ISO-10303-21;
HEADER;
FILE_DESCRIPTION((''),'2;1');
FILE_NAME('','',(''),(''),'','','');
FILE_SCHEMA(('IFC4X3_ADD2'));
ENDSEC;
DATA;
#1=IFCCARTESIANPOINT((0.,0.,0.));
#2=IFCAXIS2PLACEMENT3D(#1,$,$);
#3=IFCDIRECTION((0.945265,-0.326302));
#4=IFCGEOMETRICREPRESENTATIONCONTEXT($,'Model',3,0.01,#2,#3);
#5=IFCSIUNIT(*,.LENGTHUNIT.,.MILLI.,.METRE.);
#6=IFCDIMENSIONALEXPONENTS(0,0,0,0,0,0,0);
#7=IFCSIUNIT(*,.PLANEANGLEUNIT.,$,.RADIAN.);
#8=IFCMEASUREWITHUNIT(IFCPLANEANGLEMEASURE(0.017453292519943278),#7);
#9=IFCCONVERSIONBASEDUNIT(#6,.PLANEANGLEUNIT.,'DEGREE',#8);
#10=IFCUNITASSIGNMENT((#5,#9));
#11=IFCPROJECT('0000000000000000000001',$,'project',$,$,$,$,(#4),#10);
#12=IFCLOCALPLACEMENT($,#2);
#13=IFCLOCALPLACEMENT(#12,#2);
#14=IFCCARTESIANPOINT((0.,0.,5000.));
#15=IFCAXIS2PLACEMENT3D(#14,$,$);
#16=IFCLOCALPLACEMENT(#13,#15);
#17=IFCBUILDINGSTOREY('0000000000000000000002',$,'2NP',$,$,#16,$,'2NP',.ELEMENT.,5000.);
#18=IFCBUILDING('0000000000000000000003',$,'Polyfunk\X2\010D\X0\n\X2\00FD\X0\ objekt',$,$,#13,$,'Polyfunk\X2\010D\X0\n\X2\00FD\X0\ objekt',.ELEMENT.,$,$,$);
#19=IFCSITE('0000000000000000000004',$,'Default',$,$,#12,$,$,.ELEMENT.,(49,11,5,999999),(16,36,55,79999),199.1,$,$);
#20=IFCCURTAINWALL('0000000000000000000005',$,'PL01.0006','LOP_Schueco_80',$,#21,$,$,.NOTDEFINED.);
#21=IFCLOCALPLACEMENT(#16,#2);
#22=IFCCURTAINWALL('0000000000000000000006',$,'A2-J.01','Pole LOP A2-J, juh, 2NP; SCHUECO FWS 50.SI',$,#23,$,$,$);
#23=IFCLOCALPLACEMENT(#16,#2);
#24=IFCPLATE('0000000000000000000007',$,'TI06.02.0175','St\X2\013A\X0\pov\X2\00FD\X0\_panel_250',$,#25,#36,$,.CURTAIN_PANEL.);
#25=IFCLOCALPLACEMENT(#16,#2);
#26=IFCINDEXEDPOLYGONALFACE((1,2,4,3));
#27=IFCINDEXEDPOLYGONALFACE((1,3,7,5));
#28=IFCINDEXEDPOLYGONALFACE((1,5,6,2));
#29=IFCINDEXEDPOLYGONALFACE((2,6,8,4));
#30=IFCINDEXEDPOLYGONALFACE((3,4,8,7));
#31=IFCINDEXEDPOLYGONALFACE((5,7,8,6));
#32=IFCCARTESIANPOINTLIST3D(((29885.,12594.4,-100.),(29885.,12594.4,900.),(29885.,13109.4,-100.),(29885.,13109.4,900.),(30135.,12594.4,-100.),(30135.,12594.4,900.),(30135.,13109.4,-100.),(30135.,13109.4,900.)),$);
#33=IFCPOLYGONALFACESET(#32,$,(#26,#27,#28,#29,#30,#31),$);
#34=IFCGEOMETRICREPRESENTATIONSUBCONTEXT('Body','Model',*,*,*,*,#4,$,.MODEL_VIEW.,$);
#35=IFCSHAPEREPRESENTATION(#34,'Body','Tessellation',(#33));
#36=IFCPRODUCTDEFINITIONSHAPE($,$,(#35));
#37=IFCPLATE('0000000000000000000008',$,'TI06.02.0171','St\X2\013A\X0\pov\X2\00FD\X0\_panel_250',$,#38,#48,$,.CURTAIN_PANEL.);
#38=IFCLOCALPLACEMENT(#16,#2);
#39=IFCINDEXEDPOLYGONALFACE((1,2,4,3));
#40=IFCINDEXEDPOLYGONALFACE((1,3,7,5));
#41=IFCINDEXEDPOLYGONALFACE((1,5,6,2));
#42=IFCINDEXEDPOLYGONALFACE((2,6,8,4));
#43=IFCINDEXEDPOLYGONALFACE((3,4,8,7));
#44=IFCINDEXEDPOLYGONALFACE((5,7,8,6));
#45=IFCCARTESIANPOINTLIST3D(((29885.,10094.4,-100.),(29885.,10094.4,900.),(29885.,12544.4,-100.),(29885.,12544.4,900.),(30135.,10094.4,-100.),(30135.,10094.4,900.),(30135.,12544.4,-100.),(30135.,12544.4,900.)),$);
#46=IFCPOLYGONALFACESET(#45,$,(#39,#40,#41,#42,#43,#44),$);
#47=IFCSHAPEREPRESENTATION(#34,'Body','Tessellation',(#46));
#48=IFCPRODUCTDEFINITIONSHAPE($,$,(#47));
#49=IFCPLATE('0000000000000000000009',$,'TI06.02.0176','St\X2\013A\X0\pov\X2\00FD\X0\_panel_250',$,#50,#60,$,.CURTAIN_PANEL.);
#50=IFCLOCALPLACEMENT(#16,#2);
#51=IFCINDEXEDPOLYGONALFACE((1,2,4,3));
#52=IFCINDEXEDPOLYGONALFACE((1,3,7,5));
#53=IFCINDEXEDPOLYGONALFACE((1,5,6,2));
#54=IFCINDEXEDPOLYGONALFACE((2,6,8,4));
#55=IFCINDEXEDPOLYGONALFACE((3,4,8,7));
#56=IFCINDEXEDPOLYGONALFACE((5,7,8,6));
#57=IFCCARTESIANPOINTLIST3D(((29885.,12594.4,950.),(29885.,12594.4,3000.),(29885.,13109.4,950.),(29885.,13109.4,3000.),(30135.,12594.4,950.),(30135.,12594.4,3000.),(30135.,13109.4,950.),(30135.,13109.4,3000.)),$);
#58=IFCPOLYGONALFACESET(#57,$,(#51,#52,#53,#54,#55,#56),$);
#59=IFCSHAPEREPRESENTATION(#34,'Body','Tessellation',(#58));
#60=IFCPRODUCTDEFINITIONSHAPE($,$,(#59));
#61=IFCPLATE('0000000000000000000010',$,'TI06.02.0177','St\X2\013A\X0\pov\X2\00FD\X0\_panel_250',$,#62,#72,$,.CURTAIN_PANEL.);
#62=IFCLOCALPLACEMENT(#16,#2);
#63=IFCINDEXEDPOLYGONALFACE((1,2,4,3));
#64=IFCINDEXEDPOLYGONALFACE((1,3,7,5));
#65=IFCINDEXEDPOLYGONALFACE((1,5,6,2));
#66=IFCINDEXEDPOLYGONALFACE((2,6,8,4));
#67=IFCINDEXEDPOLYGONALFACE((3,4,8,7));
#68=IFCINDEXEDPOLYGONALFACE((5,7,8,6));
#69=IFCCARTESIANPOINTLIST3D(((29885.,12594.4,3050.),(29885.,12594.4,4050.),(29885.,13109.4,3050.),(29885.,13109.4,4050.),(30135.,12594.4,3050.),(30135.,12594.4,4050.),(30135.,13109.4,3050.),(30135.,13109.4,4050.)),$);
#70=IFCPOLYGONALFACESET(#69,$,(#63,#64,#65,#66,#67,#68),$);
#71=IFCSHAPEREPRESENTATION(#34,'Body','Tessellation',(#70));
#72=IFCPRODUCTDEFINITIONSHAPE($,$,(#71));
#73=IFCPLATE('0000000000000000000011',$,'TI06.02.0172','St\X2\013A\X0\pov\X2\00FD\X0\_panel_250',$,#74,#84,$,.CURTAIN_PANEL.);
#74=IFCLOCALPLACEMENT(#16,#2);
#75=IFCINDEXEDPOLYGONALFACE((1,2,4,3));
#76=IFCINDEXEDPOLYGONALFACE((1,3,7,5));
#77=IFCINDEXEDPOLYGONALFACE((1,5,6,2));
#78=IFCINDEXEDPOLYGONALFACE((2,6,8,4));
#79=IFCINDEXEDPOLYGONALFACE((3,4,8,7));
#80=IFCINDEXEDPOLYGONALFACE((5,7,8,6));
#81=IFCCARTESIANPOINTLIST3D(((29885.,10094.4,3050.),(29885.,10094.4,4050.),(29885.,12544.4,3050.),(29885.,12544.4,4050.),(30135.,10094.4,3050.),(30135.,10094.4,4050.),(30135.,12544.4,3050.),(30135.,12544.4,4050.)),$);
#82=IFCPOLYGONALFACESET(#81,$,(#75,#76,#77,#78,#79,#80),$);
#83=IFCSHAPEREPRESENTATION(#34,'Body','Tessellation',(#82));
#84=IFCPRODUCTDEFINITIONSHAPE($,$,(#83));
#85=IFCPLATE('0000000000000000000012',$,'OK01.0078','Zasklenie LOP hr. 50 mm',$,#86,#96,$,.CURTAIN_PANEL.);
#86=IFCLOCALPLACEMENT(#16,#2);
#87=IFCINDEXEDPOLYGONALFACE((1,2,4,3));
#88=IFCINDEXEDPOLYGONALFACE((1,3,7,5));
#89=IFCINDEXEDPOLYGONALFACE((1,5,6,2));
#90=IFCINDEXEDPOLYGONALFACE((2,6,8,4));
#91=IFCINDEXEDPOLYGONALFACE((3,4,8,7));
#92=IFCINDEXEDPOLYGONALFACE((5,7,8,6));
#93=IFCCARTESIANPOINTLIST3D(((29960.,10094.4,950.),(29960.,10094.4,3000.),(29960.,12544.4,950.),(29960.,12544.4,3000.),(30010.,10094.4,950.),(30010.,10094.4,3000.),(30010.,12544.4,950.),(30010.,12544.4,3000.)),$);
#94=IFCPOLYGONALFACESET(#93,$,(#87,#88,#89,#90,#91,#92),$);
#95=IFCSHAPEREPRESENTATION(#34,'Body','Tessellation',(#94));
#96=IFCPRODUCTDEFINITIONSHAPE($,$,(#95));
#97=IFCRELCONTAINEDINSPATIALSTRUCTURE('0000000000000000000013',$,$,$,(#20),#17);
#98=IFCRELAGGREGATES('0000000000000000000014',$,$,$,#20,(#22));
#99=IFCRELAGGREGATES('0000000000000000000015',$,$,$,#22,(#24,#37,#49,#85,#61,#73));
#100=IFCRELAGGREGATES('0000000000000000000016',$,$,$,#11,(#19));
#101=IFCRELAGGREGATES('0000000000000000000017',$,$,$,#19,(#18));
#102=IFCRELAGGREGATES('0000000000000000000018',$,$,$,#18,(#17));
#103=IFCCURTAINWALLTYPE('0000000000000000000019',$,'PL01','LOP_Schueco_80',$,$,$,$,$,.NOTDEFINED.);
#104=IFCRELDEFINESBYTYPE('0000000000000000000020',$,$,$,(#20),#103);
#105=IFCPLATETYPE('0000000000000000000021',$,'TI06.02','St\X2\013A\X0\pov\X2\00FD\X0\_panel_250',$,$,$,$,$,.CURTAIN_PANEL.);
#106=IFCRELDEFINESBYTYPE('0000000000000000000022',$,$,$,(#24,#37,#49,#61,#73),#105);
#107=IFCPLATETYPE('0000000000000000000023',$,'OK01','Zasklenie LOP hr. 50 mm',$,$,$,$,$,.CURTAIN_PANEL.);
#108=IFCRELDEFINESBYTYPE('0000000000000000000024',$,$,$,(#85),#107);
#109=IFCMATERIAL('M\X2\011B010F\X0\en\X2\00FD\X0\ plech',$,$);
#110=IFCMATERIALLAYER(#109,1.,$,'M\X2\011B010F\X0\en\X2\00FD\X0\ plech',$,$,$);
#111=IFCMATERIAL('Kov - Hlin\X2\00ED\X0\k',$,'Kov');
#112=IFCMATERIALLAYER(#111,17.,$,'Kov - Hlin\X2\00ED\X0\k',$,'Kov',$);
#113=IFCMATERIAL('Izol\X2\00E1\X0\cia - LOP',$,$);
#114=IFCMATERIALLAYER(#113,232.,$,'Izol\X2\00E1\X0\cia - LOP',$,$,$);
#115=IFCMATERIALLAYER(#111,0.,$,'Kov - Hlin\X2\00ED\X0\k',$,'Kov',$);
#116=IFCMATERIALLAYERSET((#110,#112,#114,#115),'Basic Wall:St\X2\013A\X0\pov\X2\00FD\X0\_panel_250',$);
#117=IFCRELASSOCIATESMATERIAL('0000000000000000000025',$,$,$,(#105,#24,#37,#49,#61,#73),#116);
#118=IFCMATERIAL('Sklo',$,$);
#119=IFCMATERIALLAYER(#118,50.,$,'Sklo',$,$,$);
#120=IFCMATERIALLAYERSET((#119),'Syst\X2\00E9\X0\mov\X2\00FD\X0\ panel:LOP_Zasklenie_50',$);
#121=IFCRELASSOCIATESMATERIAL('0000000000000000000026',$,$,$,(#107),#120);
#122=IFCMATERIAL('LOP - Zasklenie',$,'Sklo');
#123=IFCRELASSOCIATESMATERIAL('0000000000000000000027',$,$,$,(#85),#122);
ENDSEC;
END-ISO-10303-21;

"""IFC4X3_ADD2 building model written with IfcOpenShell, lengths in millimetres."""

from ifc_helpers import new_model, entity, si_unit, converted_unit, direction, frame, frame_2d, origin, origin_2d_with_axis, place, context, subcontext, project, spatial, rectangle, extrude, source, transform, mapped, material, layer, layer_set, layer_usage, type_object, type_shapes, element, aggregate, save


model = new_model("IFC4X3_ADD2")

# Units and contexts
model_context = context("Model", 3, precision=0.01, world=origin(), true_north=direction((0.945265, -0.326302)))
body_context = subcontext(model_context, "Body", "Model", "MODEL_VIEW")
ifc_project = project(units=[si_unit("LENGTHUNIT", "METRE", prefix="MILLI"), converted_unit("PLANEANGLEUNIT", "DEGREE", entity("IfcPlaneAngleMeasure", 0.017453292519943278), si_unit("PLANEANGLEUNIT", "RADIAN"), dimensions=[0, 0, 0, 0, 0, 0, 0])], contexts=[model_context])

# Site, building, storey
site_placement = place(None, origin())
site = spatial("IfcSite", under=ifc_project, at=site_placement, Name="Default", CompositionType="ELEMENT", RefLatitude=(49, 11, 5, 999999), RefLongitude=(16, 36, 55, 79999), RefElevation=199.1)
building_placement = place(site_placement, origin())
building = spatial("IfcBuilding", under=site, at=building_placement, Name="Polyfunkčný objekt", LongName="Polyfunkčný objekt", CompositionType="ELEMENT")
storey_placement = place(building_placement, frame((0.0, 0.0, 5000.0)))
storey = spatial("IfcBuildingStorey", under=building, at=storey_placement, Name="2NP", LongName="2NP", CompositionType="ELEMENT", Elevation=5000.0)

# Shared definitions
curtain_wall_type = type_object("IfcCurtainWallType", Name="PL01", Description="LOP_Schueco_80", PredefinedType="NOTDEFINED")

# Curtain walls, plates
curtain_wall_1_placement = place(storey_placement, frame((0.0, 0.0, -5000.0)))
curtain_wall_1 = element("IfcCurtainWall", 1, at=curtain_wall_1_placement, inside=storey, type_object=curtain_wall_type, Name="PL01.0006", Description="LOP_Schueco_80", PredefinedType="NOTDEFINED")
curtain_wall_2 = element("IfcCurtainWall", 2, Name="A2-J.01", Description="Pole LOP A2-J, juh, 2NP; SCHUECO FWS 50.SI")
aggregate(curtain_wall_1, [curtain_wall_2])
ifc_material_1 = material(Name="Měďený plech")
ifc_layer_1 = layer(ifc_material_1, 1.0, Name="Měďený plech")
ifc_material_2 = material(Name="Kov - Hliník", Category="Kov")
ifc_layer_2 = layer(ifc_material_2, 17.0, Name="Kov - Hliník", Category="Kov")
ifc_material_3 = material(Name="Izolácia - LOP")
ifc_layer_3 = layer(ifc_material_3, 232.0, Name="Izolácia - LOP")
ifc_layer_4 = layer(ifc_material_2, 0.0, Name="Kov - Hliník", Category="Kov")
ifc_layer_set_1 = layer_set([ifc_layer_1, ifc_layer_2, ifc_layer_3, ifc_layer_4], Name="Basic Wall:Stĺpový_panel_250")
ifc_layer_usage_1 = layer_usage(ifc_layer_set_1, "AXIS2", "POSITIVE", -125.0)
plate_type_1 = type_object("IfcPlateType", Name="TI06.02", Description="Stĺpový_panel_250", PredefinedType="CURTAIN_PANEL", material=ifc_layer_set_1)
plate_1_placement = place(storey_placement, frame((30010.0, 13109.4, -100.0), z_axis=(0.0, 0.0, 1.0), x_axis=(0.0, -1.0, 0.0)))
plate_1 = element("IfcPlate", 3, at=plate_1_placement, type_object=plate_type_1, material=ifc_layer_usage_1, Name="TI06.02.0175", Description="Stĺpový_panel_250", PredefinedType="CURTAIN_PANEL", context=body_context, shape_type="SweptSolid", body=[
    extrude(rectangle(XDim=250.0, YDim=515.0, at=frame_2d((0.0, 0.0), x_axis=(1.0, 0.0))), frame((257.5, 0.0, 0.0), z_axis=(0.0, 0.0, 1.0), x_axis=(0.0, 1.0, 0.0)), (0.0, 0.0, 1.0), 1000.0),
])
ifc_layer_usage_2 = layer_usage(ifc_layer_set_1, "AXIS2", "POSITIVE", -125.0)
plate_2_placement = place(storey_placement, frame((30010.0, 12544.4, -100.0), z_axis=(0.0, 0.0, 1.0), x_axis=(0.0, -1.0, 0.0)))
plate_2 = element("IfcPlate", 4, at=plate_2_placement, type_object=plate_type_1, material=ifc_layer_usage_2, Name="TI06.02.0171", Description="Stĺpový_panel_250", PredefinedType="CURTAIN_PANEL", context=body_context, shape_type="SweptSolid", body=[
    extrude(rectangle(XDim=250.0, YDim=2450.0, at=frame_2d((0.0, 0.0), x_axis=(1.0, 0.0))), frame((1225.0, 0.0, 0.0), z_axis=(0.0, 0.0, 1.0), x_axis=(0.0, 1.0, 0.0)), (0.0, 0.0, 1.0), 1000.0),
])
ifc_layer_usage_3 = layer_usage(ifc_layer_set_1, "AXIS2", "POSITIVE", -125.0)
plate_3_placement = place(storey_placement, frame((30010.0, 13109.4, 950.0), z_axis=(0.0, 0.0, 1.0), x_axis=(0.0, -1.0, 0.0)))
plate_3 = element("IfcPlate", 5, at=plate_3_placement, type_object=plate_type_1, material=ifc_layer_usage_3, Name="TI06.02.0176", Description="Stĺpový_panel_250", PredefinedType="CURTAIN_PANEL", context=body_context, shape_type="SweptSolid", body=[
    extrude(rectangle(XDim=250.0, YDim=515.0, at=frame_2d((0.0, 0.0), x_axis=(1.0, 0.0))), frame((257.5, 0.0, 0.0), z_axis=(0.0, 0.0, 1.0), x_axis=(0.0, 1.0, 0.0)), (0.0, 0.0, 1.0), 2050.0),
])
ifc_layer_usage_4 = layer_usage(ifc_layer_set_1, "AXIS2", "POSITIVE", -125.0)
plate_4_placement = place(storey_placement, frame((30010.0, 13109.4, 3050.0), z_axis=(0.0, 0.0, 1.0), x_axis=(0.0, -1.0, 0.0)))
plate_4 = element("IfcPlate", 6, at=plate_4_placement, type_object=plate_type_1, material=ifc_layer_usage_4, Name="TI06.02.0177", Description="Stĺpový_panel_250", PredefinedType="CURTAIN_PANEL", context=body_context, shape_type="SweptSolid", body=[
    extrude(rectangle(XDim=250.0, YDim=515.0, at=frame_2d((0.0, 0.0), x_axis=(1.0, 0.0))), frame((257.5, 0.0, 0.0), z_axis=(0.0, 0.0, 1.0), x_axis=(0.0, 1.0, 0.0)), (0.0, 0.0, 1.0), 1000.0),
])
ifc_layer_usage_5 = layer_usage(ifc_layer_set_1, "AXIS2", "POSITIVE", -125.0)
plate_5_placement = place(storey_placement, frame((30010.0, 12544.4, 3050.0), z_axis=(0.0, 0.0, 1.0), x_axis=(0.0, -1.0, 0.0)))
plate_5 = element("IfcPlate", 7, at=plate_5_placement, type_object=plate_type_1, material=ifc_layer_usage_5, Name="TI06.02.0172", Description="Stĺpový_panel_250", PredefinedType="CURTAIN_PANEL", context=body_context, shape_type="SweptSolid", body=[
    extrude(rectangle(XDim=250.0, YDim=2450.0, at=frame_2d((0.0, 0.0), x_axis=(1.0, 0.0))), frame((1225.0, 0.0, 0.0), z_axis=(0.0, 0.0, 1.0), x_axis=(0.0, 1.0, 0.0)), (0.0, 0.0, 1.0), 1000.0),
])
ifc_material_4 = material(Name="LOP - Zasklenie", Category="Sklo")
ifc_material_5 = material(Name="Sklo")
ifc_layer_5 = layer(ifc_material_5, 50.0, Name="Sklo")
ifc_layer_set_2 = layer_set([ifc_layer_5], Name="Systémový panel:LOP_Zasklenie_50")
plate_type_2 = type_object("IfcPlateType", Name="OK01", Description="Zasklenie LOP hr. 50 mm", PredefinedType="CURTAIN_PANEL", material=ifc_layer_set_2)
shared_shape_1 = source(origin(), body_context, "Body", "SweptSolid", [
    extrude(rectangle(XDim=50.0, YDim=2450.0, at=origin_2d_with_axis()), frame((0.0, -25.0, 0.0), z_axis=(0.0, 0.0, 1.0), x_axis=(0.0, 1.0, 0.0)), (0.0, 0.0, 1.0), 2050.0),
])
type_shapes(plate_type_2, [shared_shape_1])
plate_6_placement = place(curtain_wall_1_placement, frame((30010.0, 11319.4, 5950.0), z_axis=(0.0, 0.0, 1.0), x_axis=(0.0, -1.0, 0.0)))
plate_6 = element("IfcPlate", 8, at=plate_6_placement, type_object=plate_type_2, material=ifc_material_4, Name="OK01.0078", Description="Zasklenie LOP hr. 50 mm", PredefinedType="CURTAIN_PANEL", context=body_context, shape_type="MappedRepresentation", body=[
    mapped(shared_shape_1, transform((0.0, 0.0, 0.0), scale=1.0)),
])
aggregate(curtain_wall_2, [plate_1, plate_2, plate_3, plate_6, plate_4, plate_5])

save(model, "model.ifc")
